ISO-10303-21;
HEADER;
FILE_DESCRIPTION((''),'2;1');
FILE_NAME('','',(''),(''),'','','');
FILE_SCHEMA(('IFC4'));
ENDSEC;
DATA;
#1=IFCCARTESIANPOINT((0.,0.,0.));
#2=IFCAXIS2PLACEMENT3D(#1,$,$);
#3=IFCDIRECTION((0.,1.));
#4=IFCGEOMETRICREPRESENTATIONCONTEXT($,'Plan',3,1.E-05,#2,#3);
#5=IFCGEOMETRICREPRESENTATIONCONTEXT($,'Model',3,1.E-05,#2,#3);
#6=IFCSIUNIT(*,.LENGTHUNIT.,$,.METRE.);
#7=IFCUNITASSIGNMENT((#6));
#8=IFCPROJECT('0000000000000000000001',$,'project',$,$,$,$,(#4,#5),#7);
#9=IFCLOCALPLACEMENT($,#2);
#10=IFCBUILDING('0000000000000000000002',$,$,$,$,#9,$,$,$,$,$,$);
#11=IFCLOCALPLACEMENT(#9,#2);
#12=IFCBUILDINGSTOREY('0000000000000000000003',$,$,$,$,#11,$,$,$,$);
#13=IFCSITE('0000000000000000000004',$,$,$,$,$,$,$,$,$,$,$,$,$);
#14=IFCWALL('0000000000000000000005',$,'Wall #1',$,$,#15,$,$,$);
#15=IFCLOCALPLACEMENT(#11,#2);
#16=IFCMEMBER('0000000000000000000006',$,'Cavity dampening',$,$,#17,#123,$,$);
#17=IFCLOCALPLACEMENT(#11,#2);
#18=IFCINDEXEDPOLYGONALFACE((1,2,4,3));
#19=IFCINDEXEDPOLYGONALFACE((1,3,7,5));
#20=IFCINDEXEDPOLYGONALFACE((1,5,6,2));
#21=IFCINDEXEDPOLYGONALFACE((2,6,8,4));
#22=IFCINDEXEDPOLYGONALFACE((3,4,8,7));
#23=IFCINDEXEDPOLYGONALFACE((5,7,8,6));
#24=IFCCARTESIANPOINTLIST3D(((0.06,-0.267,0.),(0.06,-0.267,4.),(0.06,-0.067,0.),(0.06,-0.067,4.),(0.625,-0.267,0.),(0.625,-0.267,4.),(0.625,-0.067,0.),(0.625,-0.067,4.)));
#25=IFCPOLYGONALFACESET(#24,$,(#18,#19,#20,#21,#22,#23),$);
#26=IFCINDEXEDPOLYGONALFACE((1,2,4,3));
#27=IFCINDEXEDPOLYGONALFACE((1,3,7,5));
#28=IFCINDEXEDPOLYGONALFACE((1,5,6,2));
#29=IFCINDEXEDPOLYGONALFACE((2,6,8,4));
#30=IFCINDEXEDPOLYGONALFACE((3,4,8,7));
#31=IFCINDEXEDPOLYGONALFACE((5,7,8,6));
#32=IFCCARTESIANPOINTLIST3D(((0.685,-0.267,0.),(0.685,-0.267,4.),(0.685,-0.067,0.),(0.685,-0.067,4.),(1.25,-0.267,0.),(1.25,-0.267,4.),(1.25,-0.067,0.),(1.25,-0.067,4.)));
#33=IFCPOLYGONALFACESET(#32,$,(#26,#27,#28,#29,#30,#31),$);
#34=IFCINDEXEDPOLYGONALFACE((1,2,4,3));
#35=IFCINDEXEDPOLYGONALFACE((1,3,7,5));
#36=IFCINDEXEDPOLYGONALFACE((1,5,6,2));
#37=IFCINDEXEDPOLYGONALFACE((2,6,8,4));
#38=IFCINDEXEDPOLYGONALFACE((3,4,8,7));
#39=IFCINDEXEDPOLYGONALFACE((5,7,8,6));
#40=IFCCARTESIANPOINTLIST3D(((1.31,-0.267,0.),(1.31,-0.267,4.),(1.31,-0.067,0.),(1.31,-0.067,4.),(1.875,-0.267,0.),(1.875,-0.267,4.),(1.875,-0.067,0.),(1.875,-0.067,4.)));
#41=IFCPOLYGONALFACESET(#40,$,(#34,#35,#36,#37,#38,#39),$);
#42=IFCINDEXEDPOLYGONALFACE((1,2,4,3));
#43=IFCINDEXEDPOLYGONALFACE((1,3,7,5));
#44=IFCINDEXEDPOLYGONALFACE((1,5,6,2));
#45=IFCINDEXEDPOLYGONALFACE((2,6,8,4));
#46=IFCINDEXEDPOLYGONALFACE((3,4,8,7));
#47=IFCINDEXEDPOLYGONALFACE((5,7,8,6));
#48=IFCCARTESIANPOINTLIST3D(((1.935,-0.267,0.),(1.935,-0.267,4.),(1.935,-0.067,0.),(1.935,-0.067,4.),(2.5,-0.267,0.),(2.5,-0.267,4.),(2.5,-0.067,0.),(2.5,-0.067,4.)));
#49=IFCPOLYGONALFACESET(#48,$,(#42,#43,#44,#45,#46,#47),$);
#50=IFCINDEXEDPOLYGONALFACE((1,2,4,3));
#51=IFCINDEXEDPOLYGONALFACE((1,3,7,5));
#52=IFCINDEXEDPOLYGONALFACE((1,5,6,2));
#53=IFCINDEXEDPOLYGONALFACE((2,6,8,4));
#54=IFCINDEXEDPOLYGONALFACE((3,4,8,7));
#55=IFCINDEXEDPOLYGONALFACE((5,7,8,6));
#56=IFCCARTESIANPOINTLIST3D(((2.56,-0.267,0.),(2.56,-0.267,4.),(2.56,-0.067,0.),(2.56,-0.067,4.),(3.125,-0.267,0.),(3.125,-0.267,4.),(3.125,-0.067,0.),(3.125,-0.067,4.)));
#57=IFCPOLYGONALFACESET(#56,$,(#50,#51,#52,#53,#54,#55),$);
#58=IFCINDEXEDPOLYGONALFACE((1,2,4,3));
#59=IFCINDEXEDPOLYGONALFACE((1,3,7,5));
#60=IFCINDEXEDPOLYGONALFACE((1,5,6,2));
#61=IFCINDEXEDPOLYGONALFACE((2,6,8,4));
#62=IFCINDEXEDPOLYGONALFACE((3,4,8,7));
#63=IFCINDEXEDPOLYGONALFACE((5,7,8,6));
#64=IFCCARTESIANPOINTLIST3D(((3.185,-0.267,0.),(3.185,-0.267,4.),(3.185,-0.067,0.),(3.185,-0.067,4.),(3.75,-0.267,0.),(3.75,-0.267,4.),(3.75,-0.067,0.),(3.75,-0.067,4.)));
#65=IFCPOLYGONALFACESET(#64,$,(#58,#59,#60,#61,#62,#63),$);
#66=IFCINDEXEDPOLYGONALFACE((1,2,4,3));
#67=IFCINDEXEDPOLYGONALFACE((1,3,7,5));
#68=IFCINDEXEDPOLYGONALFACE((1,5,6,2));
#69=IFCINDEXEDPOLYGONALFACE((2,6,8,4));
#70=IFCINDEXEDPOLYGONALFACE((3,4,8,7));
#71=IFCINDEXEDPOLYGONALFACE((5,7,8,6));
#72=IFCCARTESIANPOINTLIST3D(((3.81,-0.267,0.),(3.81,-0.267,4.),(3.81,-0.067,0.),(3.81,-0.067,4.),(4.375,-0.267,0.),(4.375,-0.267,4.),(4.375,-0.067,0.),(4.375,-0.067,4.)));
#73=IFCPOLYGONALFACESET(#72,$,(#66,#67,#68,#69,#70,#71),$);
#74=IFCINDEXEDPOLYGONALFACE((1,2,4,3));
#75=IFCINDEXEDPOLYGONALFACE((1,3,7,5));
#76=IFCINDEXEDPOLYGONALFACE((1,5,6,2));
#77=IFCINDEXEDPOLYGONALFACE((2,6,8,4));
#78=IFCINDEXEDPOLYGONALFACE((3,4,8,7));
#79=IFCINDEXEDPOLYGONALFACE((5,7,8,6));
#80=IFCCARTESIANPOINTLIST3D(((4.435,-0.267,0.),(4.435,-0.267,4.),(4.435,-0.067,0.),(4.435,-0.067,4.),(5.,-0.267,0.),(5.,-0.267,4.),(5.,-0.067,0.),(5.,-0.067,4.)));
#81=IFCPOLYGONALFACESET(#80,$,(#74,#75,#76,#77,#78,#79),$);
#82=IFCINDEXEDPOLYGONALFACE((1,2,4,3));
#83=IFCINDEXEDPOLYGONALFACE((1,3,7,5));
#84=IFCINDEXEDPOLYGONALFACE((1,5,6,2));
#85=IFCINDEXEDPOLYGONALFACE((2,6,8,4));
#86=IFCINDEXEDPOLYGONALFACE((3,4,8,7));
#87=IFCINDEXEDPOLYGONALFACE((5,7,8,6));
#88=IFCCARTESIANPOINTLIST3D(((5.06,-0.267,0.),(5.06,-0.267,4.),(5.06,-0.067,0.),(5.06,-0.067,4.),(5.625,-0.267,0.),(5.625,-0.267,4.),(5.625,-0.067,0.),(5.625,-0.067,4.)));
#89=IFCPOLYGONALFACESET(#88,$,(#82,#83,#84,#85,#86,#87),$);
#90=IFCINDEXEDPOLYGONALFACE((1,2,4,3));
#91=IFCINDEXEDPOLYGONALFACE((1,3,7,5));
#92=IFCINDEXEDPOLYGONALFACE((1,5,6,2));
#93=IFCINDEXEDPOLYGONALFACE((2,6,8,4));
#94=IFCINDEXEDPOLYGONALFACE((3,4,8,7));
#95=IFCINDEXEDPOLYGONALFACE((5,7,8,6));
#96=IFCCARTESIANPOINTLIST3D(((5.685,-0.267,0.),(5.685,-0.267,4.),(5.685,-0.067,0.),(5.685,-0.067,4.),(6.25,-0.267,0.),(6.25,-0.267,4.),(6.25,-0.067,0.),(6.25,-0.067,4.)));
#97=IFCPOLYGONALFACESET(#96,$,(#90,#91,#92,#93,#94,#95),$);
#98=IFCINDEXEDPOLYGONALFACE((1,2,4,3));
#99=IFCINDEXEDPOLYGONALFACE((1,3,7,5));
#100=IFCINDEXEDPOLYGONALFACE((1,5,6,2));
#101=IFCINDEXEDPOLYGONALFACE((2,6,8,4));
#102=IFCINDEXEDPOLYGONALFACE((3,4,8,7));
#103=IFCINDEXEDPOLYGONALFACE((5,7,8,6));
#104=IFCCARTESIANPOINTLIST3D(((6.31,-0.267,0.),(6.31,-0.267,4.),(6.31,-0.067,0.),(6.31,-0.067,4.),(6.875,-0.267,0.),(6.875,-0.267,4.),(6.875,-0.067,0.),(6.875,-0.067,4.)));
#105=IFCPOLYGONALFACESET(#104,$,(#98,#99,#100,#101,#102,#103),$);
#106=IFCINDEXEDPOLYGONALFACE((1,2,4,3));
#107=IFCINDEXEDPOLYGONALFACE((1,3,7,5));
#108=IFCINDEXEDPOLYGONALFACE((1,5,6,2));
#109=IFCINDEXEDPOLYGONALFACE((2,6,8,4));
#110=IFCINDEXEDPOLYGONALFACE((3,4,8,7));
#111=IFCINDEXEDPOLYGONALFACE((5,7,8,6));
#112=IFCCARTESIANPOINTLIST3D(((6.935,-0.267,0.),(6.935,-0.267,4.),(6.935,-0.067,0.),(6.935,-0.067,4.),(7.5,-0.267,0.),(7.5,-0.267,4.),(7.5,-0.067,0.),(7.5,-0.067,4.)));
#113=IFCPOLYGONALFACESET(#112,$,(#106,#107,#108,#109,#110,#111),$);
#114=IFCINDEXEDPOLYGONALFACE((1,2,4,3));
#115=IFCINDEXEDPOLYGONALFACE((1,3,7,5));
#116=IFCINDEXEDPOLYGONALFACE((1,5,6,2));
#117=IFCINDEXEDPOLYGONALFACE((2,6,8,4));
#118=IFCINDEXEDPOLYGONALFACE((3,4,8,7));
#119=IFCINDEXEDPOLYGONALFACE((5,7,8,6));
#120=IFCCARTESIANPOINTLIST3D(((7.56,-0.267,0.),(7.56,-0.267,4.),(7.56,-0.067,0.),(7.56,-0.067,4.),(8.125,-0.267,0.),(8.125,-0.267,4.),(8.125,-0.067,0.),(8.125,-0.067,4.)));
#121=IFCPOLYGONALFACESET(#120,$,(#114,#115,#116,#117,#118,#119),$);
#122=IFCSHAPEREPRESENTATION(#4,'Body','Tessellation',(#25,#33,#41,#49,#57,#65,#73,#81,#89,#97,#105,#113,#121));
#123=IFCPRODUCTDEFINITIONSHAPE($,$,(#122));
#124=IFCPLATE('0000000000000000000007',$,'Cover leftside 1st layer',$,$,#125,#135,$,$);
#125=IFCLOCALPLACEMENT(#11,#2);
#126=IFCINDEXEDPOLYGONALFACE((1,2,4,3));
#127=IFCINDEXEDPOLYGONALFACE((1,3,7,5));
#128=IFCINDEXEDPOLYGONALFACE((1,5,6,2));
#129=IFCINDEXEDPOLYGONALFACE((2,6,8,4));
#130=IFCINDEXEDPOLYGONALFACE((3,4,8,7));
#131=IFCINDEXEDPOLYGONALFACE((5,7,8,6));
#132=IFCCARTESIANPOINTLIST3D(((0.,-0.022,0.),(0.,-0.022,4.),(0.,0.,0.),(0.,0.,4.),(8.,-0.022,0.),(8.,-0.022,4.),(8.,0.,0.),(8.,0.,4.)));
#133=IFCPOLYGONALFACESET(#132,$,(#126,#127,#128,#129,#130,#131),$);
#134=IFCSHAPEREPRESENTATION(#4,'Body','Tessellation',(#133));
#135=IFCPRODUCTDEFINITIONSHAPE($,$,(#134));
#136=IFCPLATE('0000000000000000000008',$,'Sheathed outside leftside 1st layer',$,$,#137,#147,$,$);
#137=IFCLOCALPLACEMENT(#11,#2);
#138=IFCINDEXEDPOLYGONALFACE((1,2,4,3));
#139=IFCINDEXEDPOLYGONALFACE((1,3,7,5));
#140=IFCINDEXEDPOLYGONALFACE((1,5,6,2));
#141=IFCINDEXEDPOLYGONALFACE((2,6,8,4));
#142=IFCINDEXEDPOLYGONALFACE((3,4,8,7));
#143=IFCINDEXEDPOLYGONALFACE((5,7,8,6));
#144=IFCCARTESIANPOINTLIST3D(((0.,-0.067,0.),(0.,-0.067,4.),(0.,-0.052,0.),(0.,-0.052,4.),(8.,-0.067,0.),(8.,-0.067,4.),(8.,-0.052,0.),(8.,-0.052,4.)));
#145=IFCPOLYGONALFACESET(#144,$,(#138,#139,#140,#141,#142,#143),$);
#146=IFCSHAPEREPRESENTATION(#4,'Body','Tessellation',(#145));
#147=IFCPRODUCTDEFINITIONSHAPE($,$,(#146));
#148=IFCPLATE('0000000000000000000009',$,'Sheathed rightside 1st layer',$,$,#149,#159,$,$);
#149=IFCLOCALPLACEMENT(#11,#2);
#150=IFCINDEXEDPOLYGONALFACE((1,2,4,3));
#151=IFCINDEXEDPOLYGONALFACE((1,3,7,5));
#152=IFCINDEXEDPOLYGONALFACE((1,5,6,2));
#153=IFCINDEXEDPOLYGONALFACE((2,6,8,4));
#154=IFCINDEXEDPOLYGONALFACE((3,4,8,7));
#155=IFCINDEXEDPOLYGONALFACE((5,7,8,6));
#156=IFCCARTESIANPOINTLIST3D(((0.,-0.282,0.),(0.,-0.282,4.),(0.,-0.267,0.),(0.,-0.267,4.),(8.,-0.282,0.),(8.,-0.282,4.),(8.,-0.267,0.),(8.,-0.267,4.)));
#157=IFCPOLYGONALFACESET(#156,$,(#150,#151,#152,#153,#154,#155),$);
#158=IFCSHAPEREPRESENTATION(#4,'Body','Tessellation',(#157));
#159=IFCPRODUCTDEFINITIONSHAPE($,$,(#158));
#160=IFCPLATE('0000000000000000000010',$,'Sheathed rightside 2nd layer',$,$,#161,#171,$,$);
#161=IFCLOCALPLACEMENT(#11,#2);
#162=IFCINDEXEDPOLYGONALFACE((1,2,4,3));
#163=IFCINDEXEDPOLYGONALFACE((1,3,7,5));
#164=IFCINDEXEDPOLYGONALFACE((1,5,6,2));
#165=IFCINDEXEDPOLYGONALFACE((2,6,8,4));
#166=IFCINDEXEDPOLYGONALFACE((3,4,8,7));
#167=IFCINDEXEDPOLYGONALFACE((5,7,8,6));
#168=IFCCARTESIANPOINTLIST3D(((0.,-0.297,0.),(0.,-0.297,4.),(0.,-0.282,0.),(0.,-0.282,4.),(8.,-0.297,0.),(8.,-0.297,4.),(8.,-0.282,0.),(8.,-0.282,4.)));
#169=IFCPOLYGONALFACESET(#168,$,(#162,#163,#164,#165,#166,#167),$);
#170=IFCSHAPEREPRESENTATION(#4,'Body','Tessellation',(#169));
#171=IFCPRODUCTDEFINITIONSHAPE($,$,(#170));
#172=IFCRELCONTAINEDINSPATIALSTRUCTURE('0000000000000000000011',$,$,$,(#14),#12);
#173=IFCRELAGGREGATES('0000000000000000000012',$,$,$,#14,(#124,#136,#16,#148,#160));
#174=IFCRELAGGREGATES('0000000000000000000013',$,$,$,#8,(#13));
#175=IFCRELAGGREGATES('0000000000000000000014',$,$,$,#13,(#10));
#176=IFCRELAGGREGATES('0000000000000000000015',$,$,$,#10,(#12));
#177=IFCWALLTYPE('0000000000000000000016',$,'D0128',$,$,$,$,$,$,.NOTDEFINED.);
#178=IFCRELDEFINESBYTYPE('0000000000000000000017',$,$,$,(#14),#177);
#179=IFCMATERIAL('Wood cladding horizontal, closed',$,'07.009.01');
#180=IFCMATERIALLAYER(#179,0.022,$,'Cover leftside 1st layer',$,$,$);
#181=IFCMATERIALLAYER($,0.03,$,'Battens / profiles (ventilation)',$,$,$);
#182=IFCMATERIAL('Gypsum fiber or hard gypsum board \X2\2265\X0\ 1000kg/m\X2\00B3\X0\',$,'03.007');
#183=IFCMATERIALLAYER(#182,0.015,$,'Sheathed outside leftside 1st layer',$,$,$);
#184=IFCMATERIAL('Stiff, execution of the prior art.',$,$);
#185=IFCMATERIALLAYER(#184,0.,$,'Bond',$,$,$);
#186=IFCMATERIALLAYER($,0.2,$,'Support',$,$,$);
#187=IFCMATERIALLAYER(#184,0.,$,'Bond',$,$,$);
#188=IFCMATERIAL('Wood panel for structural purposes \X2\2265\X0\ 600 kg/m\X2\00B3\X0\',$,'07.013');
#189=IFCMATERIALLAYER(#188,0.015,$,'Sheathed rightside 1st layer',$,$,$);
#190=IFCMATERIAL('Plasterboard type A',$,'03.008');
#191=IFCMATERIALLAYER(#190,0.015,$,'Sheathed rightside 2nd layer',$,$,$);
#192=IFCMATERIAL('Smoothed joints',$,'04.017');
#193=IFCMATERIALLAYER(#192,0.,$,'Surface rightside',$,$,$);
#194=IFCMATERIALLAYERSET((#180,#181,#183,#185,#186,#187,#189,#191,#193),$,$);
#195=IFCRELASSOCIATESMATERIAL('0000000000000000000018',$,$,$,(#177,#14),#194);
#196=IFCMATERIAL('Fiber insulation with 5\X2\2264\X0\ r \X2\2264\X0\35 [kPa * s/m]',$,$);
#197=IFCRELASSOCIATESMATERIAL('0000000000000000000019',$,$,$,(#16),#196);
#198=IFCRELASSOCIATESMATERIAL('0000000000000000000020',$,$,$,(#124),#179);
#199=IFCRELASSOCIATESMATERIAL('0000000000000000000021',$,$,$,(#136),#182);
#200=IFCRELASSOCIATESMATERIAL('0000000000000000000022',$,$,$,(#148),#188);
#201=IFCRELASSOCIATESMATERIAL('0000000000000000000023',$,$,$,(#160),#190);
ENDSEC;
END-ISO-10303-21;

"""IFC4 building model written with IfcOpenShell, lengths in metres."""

from ifc_helpers import new_model, si_unit, direction, frame, frame_2d, origin, origin_with_axes, place, context, project, spatial, rectangle, extrude, material, layer, layer_set, type_object, element, aggregate, save


model = new_model("IFC4")

# Units and contexts
plan_context = context("Plan", 3, precision=1e-05, world=origin(), true_north=direction((0.0, 1.0)))
model_context = context("Model", 3, precision=1e-05, world=origin(), true_north=direction((0.0, 1.0)))
ifc_project = project(units=[si_unit("LENGTHUNIT", "METRE")], contexts=[plan_context, model_context])

# Site, building, storey
site = spatial("IfcSite", under=ifc_project)
building_placement = place(None, origin())
building = spatial("IfcBuilding", under=site, at=building_placement)
storey_placement = place(building_placement, origin())
storey = spatial("IfcBuildingStorey", under=building, at=storey_placement)

# Wall, member, plates
ifc_material_1 = material(Name="Wood cladding horizontal, closed", Category="07.009.01")
ifc_layer_1 = layer(ifc_material_1, 0.022, Name="Cover leftside 1st layer")
ifc_layer_2 = layer(None, 0.03, Name="Battens / profiles (ventilation)")
ifc_material_2 = material(Name="Gypsum fiber or hard gypsum board ≥ 1000kg/m³", Category="03.007")
ifc_layer_3 = layer(ifc_material_2, 0.015, Name="Sheathed outside leftside 1st layer")
ifc_material_3 = material(Name="Stiff, execution of the prior art.")
ifc_layer_4 = layer(ifc_material_3, 0.0, Name="Bond")
ifc_layer_5 = layer(None, 0.2, Name="Support")
ifc_layer_6 = layer(ifc_material_3, 0.0, Name="Bond")
ifc_material_4 = material(Name="Wood panel for structural purposes ≥ 600 kg/m³", Category="07.013")
ifc_layer_7 = layer(ifc_material_4, 0.015, Name="Sheathed rightside 1st layer")
ifc_material_5 = material(Name="Plasterboard type A", Category="03.008")
ifc_layer_8 = layer(ifc_material_5, 0.015, Name="Sheathed rightside 2nd layer")
ifc_material_6 = material(Name="Smoothed joints", Category="04.017")
ifc_layer_9 = layer(ifc_material_6, 0.0, Name="Surface rightside")
ifc_layer_set = layer_set([ifc_layer_1, ifc_layer_2, ifc_layer_3, ifc_layer_4, ifc_layer_5, ifc_layer_6, ifc_layer_7, ifc_layer_8, ifc_layer_9])
wall_type = type_object("IfcWallType", Name="D0128", PredefinedType="NOTDEFINED", material=ifc_layer_set)
wall_placement = place(None, frame((0.0, 0.0, 0.0), z_axis=(0.0, -1.0, 0.0), x_axis=(1.0, 0.0, 0.0)))
wall = element("IfcWall", 1, at=wall_placement, inside=storey, type_object=wall_type, material=ifc_layer_set, Name="Wall #1")
ifc_material_7 = material(Name="Fiber insulation with 5≤ r ≤35 [kPa * s/m]")
member_1_placement = place(wall_placement, origin())
member_1 = element("IfcMember", 2, at=member_1_placement, material=ifc_material_7, Name="Cavity dampening", context=plan_context, shape_type="SweptSolid", body=[
    extrude(rectangle(XDim=0.565, YDim=0.2, at=frame_2d((0.2825, 0.1), x_axis=(1.0, 0.0))), frame((0.06, 4.0, 0.067), z_axis=(0.0, -1.0, 0.0), x_axis=(1.0, 0.0, 0.0)), (0.0, 0.0, 1.0), 4.0),
    extrude(rectangle(XDim=0.565, YDim=0.2, at=frame_2d((0.2825, 0.1), x_axis=(1.0, 0.0))), frame((0.685, 4.0, 0.067), z_axis=(0.0, -1.0, 0.0), x_axis=(1.0, 0.0, 0.0)), (0.0, 0.0, 1.0), 4.0),
    extrude(rectangle(XDim=0.565, YDim=0.2, at=frame_2d((0.2825, 0.1), x_axis=(1.0, 0.0))), frame((1.31, 4.0, 0.067), z_axis=(0.0, -1.0, 0.0), x_axis=(1.0, 0.0, 0.0)), (0.0, 0.0, 1.0), 4.0),
    extrude(rectangle(XDim=0.565, YDim=0.2, at=frame_2d((0.2825, 0.1), x_axis=(1.0, 0.0))), frame((1.935, 4.0, 0.067), z_axis=(0.0, -1.0, 0.0), x_axis=(1.0, 0.0, 0.0)), (0.0, 0.0, 1.0), 4.0),
    extrude(rectangle(XDim=0.565, YDim=0.2, at=frame_2d((0.2825, 0.1), x_axis=(1.0, 0.0))), frame((2.56, 4.0, 0.067), z_axis=(0.0, -1.0, 0.0), x_axis=(1.0, 0.0, 0.0)), (0.0, 0.0, 1.0), 4.0),
    extrude(rectangle(XDim=0.565, YDim=0.2, at=frame_2d((0.2825, 0.1), x_axis=(1.0, 0.0))), frame((3.185, 4.0, 0.067), z_axis=(0.0, -1.0, 0.0), x_axis=(1.0, 0.0, 0.0)), (0.0, 0.0, 1.0), 4.0),
    extrude(rectangle(XDim=0.565, YDim=0.2, at=frame_2d((0.2825, 0.1), x_axis=(1.0, 0.0))), frame((3.81, 4.0, 0.067), z_axis=(0.0, -1.0, 0.0), x_axis=(1.0, 0.0, 0.0)), (0.0, 0.0, 1.0), 4.0),
    extrude(rectangle(XDim=0.565, YDim=0.2, at=frame_2d((0.2825, 0.1), x_axis=(1.0, 0.0))), frame((4.435, 4.0, 0.067), z_axis=(0.0, -1.0, 0.0), x_axis=(1.0, 0.0, 0.0)), (0.0, 0.0, 1.0), 4.0),
    extrude(rectangle(XDim=0.565, YDim=0.2, at=frame_2d((0.2825, 0.1), x_axis=(1.0, 0.0))), frame((5.06, 4.0, 0.067), z_axis=(0.0, -1.0, 0.0), x_axis=(1.0, 0.0, 0.0)), (0.0, 0.0, 1.0), 4.0),
    extrude(rectangle(XDim=0.565, YDim=0.2, at=frame_2d((0.2825, 0.1), x_axis=(1.0, 0.0))), frame((5.685, 4.0, 0.067), z_axis=(0.0, -1.0, 0.0), x_axis=(1.0, 0.0, 0.0)), (0.0, 0.0, 1.0), 4.0),
    extrude(rectangle(XDim=0.565, YDim=0.2, at=frame_2d((0.2825, 0.1), x_axis=(1.0, 0.0))), frame((6.31, 4.0, 0.067), z_axis=(0.0, -1.0, 0.0), x_axis=(1.0, 0.0, 0.0)), (0.0, 0.0, 1.0), 4.0),
    extrude(rectangle(XDim=0.565, YDim=0.2, at=frame_2d((0.2825, 0.1), x_axis=(1.0, 0.0))), frame((6.935, 4.0, 0.067), z_axis=(0.0, -1.0, 0.0), x_axis=(1.0, 0.0, 0.0)), (0.0, 0.0, 1.0), 4.0),
    extrude(rectangle(XDim=0.565, YDim=0.2, at=frame_2d((0.2825, 0.1), x_axis=(1.0, 0.0))), frame((7.56, 4.0, 0.067), z_axis=(0.0, -1.0, 0.0), x_axis=(1.0, 0.0, 0.0)), (0.0, 0.0, 1.0), 4.0),
])
plate_1_placement = place(wall_placement, origin())
plate_1 = element("IfcPlate", 3, at=plate_1_placement, material=ifc_material_1, Name="Cover leftside 1st layer", context=plan_context, shape_type="SweptSolid", body=[
    extrude(rectangle(XDim=8.0, YDim=4.0, at=frame_2d((4.0, 2.0), x_axis=(1.0, 0.0))), origin_with_axes(), (0.0, 0.0, 1.0), 0.022),
])
plate_2_placement = place(wall_placement, origin())
plate_2 = element("IfcPlate", 4, at=plate_2_placement, material=ifc_material_2, Name="Sheathed outside leftside 1st layer", context=plan_context, shape_type="SweptSolid", body=[
    extrude(rectangle(XDim=8.0, YDim=4.0, at=frame_2d((4.0, 2.0), x_axis=(1.0, 0.0))), frame((0.0, 0.0, 0.052), z_axis=(0.0, 0.0, 1.0), x_axis=(1.0, 0.0, 0.0)), (0.0, 0.0, 1.0), 0.015),
])
plate_3_placement = place(wall_placement, origin())
plate_3 = element("IfcPlate", 5, at=plate_3_placement, material=ifc_material_4, Name="Sheathed rightside 1st layer", context=plan_context, shape_type="SweptSolid", body=[
    extrude(rectangle(XDim=8.0, YDim=4.0, at=frame_2d((4.0, 2.0), x_axis=(1.0, 0.0))), frame((0.0, 0.0, 0.267), z_axis=(0.0, 0.0, 1.0), x_axis=(1.0, 0.0, 0.0)), (0.0, 0.0, 1.0), 0.015),
])
plate_4_placement = place(wall_placement, origin())
plate_4 = element("IfcPlate", 6, at=plate_4_placement, material=ifc_material_5, Name="Sheathed rightside 2nd layer", context=plan_context, shape_type="SweptSolid", body=[
    extrude(rectangle(XDim=8.0, YDim=4.0, at=frame_2d((4.0, 2.0), x_axis=(1.0, 0.0))), frame((0.0, 0.0, 0.282), z_axis=(0.0, 0.0, 1.0), x_axis=(1.0, 0.0, 0.0)), (0.0, 0.0, 1.0), 0.015),
])
aggregate(wall, [plate_1, plate_2, member_1, plate_3, plate_4])

save(model, "model.ifc")
